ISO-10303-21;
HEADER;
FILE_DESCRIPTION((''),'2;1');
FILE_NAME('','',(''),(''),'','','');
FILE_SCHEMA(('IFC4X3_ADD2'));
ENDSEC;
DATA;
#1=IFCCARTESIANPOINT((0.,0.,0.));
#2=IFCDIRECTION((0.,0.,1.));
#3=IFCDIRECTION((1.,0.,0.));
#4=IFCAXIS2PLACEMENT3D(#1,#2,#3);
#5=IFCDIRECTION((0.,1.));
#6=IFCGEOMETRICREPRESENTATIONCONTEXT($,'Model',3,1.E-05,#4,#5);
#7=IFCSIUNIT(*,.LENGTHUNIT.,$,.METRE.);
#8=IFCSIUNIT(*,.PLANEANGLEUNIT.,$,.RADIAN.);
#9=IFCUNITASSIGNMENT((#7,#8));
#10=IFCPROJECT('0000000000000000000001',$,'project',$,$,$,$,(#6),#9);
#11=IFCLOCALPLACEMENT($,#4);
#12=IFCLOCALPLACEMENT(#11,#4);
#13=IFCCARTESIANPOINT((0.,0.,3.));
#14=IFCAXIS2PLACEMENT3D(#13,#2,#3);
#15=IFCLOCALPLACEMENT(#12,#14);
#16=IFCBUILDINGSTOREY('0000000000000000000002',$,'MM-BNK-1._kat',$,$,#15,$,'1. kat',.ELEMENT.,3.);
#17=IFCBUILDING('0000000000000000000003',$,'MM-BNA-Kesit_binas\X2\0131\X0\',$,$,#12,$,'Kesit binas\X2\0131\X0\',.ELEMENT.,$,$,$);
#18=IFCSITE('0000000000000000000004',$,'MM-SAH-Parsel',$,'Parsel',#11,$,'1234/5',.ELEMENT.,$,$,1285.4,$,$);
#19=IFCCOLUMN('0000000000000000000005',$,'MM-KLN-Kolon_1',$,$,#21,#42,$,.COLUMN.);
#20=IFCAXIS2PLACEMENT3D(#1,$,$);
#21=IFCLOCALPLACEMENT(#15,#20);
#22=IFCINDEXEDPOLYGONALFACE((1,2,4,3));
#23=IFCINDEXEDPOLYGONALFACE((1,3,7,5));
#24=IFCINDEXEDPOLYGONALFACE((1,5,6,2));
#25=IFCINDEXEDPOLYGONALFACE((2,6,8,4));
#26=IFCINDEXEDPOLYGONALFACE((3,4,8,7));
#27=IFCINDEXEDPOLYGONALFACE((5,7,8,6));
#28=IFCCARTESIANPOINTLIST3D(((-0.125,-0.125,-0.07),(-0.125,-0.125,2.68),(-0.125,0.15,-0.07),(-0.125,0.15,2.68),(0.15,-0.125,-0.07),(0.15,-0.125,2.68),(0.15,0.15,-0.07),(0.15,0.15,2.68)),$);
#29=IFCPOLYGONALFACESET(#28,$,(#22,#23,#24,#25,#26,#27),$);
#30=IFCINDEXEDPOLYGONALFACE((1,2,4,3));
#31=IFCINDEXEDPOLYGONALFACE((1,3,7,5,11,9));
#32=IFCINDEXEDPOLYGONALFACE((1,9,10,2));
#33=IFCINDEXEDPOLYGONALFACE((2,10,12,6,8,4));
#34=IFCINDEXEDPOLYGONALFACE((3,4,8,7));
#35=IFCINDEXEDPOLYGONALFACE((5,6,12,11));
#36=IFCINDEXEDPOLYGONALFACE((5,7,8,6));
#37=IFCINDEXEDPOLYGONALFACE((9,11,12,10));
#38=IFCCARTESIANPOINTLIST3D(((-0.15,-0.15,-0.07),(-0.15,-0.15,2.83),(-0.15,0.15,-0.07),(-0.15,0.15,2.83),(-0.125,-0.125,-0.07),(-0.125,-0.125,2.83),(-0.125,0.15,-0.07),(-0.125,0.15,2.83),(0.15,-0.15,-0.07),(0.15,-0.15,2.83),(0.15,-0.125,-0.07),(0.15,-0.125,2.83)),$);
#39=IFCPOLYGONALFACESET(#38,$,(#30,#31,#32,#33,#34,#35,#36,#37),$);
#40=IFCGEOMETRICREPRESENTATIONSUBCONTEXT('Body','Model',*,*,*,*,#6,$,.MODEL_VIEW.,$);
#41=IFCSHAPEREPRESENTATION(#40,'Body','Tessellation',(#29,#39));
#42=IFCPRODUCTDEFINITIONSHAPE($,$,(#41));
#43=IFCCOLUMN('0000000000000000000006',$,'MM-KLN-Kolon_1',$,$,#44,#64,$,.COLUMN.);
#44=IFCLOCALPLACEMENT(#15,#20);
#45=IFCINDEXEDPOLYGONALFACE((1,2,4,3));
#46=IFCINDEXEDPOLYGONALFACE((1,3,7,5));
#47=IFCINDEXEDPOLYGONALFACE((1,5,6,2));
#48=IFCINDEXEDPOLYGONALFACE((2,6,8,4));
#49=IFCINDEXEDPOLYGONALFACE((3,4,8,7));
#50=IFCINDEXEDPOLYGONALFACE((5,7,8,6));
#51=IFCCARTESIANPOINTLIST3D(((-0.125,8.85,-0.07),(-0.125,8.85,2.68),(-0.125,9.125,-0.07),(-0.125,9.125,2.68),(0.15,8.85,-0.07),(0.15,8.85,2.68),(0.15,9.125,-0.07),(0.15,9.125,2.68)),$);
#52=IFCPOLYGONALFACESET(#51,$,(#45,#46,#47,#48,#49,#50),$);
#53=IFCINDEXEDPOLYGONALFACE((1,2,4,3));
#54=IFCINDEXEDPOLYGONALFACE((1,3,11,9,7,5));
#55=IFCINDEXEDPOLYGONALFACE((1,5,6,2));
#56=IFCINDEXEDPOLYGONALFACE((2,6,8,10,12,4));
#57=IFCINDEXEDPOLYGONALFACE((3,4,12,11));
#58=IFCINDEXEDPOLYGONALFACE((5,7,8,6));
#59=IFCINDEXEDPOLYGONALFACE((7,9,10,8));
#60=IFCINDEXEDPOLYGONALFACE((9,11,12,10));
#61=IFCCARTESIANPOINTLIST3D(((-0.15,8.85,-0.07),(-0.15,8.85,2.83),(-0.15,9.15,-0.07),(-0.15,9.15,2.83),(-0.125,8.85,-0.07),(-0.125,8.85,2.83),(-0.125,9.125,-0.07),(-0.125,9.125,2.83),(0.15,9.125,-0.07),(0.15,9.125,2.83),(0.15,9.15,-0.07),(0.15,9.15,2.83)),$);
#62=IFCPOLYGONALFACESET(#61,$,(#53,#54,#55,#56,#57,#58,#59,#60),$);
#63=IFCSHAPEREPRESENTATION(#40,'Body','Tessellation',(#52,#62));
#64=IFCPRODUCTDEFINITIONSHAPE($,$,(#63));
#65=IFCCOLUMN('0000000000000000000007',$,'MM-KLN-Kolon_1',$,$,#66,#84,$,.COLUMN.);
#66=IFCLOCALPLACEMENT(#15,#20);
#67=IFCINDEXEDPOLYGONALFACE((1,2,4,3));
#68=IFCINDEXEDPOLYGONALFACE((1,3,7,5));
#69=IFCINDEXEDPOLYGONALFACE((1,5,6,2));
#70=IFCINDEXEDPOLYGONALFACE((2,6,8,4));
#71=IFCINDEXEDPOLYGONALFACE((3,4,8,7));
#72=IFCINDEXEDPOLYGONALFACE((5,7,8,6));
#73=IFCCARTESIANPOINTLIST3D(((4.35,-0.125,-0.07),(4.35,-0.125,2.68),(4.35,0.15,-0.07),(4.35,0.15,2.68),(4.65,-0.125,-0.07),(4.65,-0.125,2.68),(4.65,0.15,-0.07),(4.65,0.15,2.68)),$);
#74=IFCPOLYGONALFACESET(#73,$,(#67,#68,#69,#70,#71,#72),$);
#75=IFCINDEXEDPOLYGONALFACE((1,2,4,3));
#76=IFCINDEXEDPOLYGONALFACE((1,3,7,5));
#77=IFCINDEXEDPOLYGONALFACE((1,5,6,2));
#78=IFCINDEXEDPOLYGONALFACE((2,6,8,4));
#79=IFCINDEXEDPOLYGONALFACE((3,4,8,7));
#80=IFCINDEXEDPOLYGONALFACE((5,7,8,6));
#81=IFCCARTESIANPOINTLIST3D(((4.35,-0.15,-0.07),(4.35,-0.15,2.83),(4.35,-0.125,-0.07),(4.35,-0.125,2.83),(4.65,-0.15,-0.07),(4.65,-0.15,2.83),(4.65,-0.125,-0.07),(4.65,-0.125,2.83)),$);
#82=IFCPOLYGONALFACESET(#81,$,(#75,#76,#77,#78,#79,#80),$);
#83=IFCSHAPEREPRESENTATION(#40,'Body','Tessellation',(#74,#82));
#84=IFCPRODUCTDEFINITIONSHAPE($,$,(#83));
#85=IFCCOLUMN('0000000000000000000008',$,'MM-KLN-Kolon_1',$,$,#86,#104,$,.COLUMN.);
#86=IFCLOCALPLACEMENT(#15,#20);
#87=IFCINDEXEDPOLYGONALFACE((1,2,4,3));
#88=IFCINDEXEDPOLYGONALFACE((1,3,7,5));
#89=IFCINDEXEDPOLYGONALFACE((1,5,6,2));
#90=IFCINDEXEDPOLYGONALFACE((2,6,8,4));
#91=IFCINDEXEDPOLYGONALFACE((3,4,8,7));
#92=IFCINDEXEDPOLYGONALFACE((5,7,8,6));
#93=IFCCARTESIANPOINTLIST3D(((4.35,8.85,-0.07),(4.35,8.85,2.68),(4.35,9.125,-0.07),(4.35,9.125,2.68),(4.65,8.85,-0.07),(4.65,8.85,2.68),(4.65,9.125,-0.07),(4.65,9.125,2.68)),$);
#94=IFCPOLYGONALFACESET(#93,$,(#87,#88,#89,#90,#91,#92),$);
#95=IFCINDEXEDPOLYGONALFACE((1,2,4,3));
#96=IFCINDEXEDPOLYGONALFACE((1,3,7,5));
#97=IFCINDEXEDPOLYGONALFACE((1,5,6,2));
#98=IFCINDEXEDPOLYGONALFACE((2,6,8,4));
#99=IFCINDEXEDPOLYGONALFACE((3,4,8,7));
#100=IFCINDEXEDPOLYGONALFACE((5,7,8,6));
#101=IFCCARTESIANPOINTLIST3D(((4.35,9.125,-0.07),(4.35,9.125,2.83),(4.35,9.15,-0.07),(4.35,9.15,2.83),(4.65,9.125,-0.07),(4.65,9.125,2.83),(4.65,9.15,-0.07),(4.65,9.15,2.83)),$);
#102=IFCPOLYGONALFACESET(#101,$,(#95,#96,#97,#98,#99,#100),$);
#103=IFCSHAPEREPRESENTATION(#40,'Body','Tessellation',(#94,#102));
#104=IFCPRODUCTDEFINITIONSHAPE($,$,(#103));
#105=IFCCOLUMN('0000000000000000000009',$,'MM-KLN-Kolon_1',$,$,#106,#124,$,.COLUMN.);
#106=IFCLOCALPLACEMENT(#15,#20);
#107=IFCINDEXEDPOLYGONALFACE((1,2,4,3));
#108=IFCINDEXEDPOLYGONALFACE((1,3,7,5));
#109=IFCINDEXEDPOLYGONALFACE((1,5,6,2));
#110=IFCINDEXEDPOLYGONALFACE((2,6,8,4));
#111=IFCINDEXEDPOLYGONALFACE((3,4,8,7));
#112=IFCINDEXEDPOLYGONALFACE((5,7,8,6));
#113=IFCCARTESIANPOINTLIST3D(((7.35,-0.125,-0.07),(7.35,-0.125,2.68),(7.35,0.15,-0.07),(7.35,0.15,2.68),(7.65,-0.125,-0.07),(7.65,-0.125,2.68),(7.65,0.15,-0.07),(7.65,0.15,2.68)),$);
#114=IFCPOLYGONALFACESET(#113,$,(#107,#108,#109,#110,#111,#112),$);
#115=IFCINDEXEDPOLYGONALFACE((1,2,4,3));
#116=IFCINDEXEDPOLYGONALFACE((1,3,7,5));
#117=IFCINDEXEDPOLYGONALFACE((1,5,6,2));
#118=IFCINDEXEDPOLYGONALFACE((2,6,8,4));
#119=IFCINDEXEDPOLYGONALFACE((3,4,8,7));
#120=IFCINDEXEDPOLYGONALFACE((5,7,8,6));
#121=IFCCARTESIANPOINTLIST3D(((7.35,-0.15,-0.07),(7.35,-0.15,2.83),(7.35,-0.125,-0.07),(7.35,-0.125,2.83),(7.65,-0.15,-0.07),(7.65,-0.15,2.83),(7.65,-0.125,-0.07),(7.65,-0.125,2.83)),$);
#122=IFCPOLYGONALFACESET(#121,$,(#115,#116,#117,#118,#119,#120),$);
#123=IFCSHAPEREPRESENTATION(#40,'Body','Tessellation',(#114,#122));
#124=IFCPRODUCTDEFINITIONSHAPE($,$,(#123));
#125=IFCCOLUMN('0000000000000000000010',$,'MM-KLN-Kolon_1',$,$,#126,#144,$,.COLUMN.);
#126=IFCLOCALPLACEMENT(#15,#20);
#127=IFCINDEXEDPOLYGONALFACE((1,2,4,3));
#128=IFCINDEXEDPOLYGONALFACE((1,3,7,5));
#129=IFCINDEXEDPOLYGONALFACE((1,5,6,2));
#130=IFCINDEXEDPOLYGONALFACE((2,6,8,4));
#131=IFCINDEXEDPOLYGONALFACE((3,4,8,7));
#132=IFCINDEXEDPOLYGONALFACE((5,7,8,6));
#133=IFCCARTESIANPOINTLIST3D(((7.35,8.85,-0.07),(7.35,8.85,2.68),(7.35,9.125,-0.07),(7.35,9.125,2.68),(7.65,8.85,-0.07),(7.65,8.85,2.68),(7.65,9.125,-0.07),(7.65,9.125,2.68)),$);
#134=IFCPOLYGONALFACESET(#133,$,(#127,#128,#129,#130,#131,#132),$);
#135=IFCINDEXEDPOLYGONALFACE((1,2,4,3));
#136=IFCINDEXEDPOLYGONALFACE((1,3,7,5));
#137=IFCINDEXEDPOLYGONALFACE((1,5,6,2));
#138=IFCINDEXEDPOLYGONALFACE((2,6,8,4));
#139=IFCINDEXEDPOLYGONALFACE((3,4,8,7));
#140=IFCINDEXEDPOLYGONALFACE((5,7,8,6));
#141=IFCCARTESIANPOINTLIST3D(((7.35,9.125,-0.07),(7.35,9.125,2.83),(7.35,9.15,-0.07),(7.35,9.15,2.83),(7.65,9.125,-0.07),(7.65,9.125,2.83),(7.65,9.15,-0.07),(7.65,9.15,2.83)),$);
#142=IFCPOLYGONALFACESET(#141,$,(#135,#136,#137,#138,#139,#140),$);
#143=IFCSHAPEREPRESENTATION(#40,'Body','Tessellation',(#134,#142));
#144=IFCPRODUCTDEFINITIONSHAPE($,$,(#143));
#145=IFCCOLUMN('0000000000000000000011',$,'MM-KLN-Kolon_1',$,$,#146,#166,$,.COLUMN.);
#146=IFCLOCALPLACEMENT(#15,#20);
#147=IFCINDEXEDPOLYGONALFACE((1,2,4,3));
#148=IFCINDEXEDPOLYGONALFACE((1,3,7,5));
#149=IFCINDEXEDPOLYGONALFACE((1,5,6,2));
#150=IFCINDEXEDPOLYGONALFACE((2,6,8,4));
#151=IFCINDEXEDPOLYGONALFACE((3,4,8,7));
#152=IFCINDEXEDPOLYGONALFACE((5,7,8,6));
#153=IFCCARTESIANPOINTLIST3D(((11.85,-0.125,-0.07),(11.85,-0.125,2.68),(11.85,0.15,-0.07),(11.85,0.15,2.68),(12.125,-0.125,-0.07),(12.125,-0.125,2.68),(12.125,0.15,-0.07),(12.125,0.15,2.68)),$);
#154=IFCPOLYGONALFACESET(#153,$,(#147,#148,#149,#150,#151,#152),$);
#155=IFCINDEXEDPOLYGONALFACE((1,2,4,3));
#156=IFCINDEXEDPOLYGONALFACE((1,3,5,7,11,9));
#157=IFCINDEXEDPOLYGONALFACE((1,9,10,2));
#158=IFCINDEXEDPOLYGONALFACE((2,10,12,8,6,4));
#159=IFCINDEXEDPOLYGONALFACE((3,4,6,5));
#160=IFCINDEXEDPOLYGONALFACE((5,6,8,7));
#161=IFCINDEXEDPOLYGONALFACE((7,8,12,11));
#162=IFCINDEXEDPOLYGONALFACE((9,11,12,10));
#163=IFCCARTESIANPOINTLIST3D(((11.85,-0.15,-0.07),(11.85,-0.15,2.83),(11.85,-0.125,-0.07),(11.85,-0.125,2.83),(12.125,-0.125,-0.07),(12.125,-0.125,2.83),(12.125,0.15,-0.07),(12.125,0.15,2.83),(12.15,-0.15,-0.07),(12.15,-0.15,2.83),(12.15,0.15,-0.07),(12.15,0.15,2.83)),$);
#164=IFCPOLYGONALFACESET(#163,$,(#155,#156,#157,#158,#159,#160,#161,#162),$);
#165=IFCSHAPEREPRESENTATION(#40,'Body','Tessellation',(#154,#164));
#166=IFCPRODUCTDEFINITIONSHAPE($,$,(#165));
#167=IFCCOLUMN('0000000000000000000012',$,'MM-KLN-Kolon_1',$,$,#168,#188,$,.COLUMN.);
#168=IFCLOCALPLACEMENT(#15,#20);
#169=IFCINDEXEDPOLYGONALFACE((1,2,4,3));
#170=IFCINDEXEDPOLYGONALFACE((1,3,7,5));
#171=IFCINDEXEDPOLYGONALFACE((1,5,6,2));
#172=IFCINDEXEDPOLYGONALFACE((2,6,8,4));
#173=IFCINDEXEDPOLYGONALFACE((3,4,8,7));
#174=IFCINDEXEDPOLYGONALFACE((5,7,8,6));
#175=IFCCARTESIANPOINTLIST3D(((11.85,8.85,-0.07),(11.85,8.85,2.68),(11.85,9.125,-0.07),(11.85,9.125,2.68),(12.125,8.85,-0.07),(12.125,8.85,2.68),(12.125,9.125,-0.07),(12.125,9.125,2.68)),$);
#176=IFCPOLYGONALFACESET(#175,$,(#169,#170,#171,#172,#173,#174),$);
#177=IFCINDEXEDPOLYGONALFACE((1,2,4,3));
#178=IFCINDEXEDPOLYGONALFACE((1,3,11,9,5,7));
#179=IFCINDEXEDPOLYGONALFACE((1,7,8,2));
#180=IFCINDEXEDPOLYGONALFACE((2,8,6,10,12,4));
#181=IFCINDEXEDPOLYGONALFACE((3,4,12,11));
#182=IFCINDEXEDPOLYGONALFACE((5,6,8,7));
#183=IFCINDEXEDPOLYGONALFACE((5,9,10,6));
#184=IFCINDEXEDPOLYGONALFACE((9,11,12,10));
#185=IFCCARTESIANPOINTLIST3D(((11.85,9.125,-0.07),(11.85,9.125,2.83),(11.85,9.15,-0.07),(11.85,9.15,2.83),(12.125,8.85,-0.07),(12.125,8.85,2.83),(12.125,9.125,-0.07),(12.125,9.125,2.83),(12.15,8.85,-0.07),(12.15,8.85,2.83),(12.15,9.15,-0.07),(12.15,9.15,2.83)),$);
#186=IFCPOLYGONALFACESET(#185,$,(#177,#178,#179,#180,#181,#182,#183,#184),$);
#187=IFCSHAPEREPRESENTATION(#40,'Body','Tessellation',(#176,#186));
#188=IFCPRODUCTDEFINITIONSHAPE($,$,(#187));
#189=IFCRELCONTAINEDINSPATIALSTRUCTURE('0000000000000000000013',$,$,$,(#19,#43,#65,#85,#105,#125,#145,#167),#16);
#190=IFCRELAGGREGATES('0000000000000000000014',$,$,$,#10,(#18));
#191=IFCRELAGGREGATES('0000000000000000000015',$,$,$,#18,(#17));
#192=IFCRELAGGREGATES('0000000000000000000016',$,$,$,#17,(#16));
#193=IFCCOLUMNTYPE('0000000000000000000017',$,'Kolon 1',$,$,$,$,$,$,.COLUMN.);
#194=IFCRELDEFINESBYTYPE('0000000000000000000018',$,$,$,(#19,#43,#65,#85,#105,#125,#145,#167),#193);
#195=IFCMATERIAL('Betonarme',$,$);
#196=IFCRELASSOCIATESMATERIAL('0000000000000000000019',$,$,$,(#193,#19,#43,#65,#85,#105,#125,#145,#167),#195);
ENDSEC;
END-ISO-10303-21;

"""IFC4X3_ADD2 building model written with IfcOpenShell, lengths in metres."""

from ifc_helpers import new_model, si_unit, direction, frame, origin_with_axes, place, context, subcontext, project, spatial, polyline, rectangle, outline, extrude, material, material_profile, profile_set, type_object, element, save


model = new_model("IFC4X3_ADD2")

# Units and contexts
model_context = context("Model", 3, precision=1e-05, world=origin_with_axes(), true_north=direction((0.0, 1.0)))
body_context = subcontext(model_context, "Body", "Model", "MODEL_VIEW")
ifc_project = project(units=[si_unit("LENGTHUNIT", "METRE"), si_unit("PLANEANGLEUNIT", "RADIAN")], contexts=[model_context])

# Site, building, storey
site_placement = place(None, origin_with_axes())
site = spatial("IfcSite", under=ifc_project, at=site_placement, Name="MM-SAH-Parsel", ObjectType="Parsel", LongName="1234/5", CompositionType="ELEMENT", RefElevation=1285.4)
building_placement = place(site_placement, origin_with_axes())
building = spatial("IfcBuilding", under=site, at=building_placement, Name="MM-BNA-Kesit_binası", LongName="Kesit binası", CompositionType="ELEMENT")
storey_placement = place(building_placement, frame((0.0, 0.0, 3.0), z_axis=(0.0, 0.0, 1.0), x_axis=(1.0, 0.0, 0.0)))
storey = spatial("IfcBuildingStorey", under=building, at=storey_placement, Name="MM-BNK-1._kat", LongName="1. kat", CompositionType="ELEMENT", Elevation=3.0)

# Columns
ifc_material_1 = material(Name="Betonarme")
ifc_material_profile_1 = material_profile(ifc_material_1, rectangle(XDim=0.3, YDim=0.3), Category="LoadBearing")
ifc_profile_set_1 = profile_set([ifc_material_profile_1], Name="Kolon 1")
column_type = type_object("IfcColumnType", Name="Kolon 1", PredefinedType="COLUMN", material=ifc_profile_set_1)
column_1_placement = place(storey_placement, origin_with_axes())
element("IfcColumn", 1, at=column_1_placement, inside=storey, type_object=column_type, material=ifc_material_1, Name="MM-KLN-Kolon_1", PredefinedType="COLUMN", context=body_context, shape_type="SweptSolid", body=[
    extrude(outline(polyline([(0.15, -0.125), (0.15, 0.15), (-0.125, 0.15), (-0.125, -0.125), (0.15, -0.125)])), frame((0.0, 0.0, -0.07)), (0.0, 0.0, 1.0), 2.75),
    extrude(outline(polyline([(-0.15, -0.15), (0.15, -0.15), (0.15, -0.125), (-0.125, -0.125), (-0.125, 0.15), (-0.15, 0.15), (-0.15, -0.15)])), frame((0.0, 0.0, -0.07)), (0.0, 0.0, 1.0), 2.9),
])
column_2_placement = place(storey_placement, origin_with_axes())
element("IfcColumn", 2, at=column_2_placement, inside=storey, type_object=column_type, material=ifc_material_1, Name="MM-KLN-Kolon_1", PredefinedType="COLUMN", context=body_context, shape_type="SweptSolid", body=[
    extrude(outline(polyline([(-0.125, 8.85), (0.15, 8.85), (0.15, 9.125), (-0.125, 9.125), (-0.125, 8.85)])), frame((0.0, 0.0, -0.07)), (0.0, 0.0, 1.0), 2.75),
    extrude(outline(polyline([(-0.15, 8.85), (-0.125, 8.85), (-0.125, 9.125), (0.15, 9.125), (0.15, 9.15), (-0.15, 9.15), (-0.15, 8.85)])), frame((0.0, 0.0, -0.07)), (0.0, 0.0, 1.0), 2.9),
])
column_3_placement = place(storey_placement, origin_with_axes())
element("IfcColumn", 3, at=column_3_placement, inside=storey, type_object=column_type, material=ifc_material_1, Name="MM-KLN-Kolon_1", PredefinedType="COLUMN", context=body_context, shape_type="SweptSolid", body=[
    extrude(outline(polyline([(4.65, -0.125), (4.65, 0.15), (4.35, 0.15), (4.35, -0.125), (4.65, -0.125)])), frame((0.0, 0.0, -0.07)), (0.0, 0.0, 1.0), 2.75),
    extrude(outline(polyline([(4.35, -0.15), (4.65, -0.15), (4.65, -0.125), (4.35, -0.125), (4.35, -0.15)])), frame((0.0, 0.0, -0.07)), (0.0, 0.0, 1.0), 2.9),
])
column_4_placement = place(storey_placement, origin_with_axes())
element("IfcColumn", 4, at=column_4_placement, inside=storey, type_object=column_type, material=ifc_material_1, Name="MM-KLN-Kolon_1", PredefinedType="COLUMN", context=body_context, shape_type="SweptSolid", body=[
    extrude(outline(polyline([(4.35, 8.85), (4.65, 8.85), (4.65, 9.125), (4.35, 9.125), (4.35, 8.85)])), frame((0.0, 0.0, -0.07)), (0.0, 0.0, 1.0), 2.75),
    extrude(outline(polyline([(4.65, 9.125), (4.65, 9.15), (4.35, 9.15), (4.35, 9.125), (4.65, 9.125)])), frame((0.0, 0.0, -0.07)), (0.0, 0.0, 1.0), 2.9),
])
column_5_placement = place(storey_placement, origin_with_axes())
element("IfcColumn", 5, at=column_5_placement, inside=storey, type_object=column_type, material=ifc_material_1, Name="MM-KLN-Kolon_1", PredefinedType="COLUMN", context=body_context, shape_type="SweptSolid", body=[
    extrude(outline(polyline([(7.65, -0.125), (7.65, 0.15), (7.35, 0.15), (7.35, -0.125), (7.65, -0.125)])), frame((0.0, 0.0, -0.07)), (0.0, 0.0, 1.0), 2.75),
    extrude(outline(polyline([(7.35, -0.15), (7.65, -0.15), (7.65, -0.125), (7.35, -0.125), (7.35, -0.15)])), frame((0.0, 0.0, -0.07)), (0.0, 0.0, 1.0), 2.9),
])
column_6_placement = place(storey_placement, origin_with_axes())
element("IfcColumn", 6, at=column_6_placement, inside=storey, type_object=column_type, material=ifc_material_1, Name="MM-KLN-Kolon_1", PredefinedType="COLUMN", context=body_context, shape_type="SweptSolid", body=[
    extrude(outline(polyline([(7.35, 8.85), (7.65, 8.85), (7.65, 9.125), (7.35, 9.125), (7.35, 8.85)])), frame((0.0, 0.0, -0.07)), (0.0, 0.0, 1.0), 2.75),
    extrude(outline(polyline([(7.65, 9.125), (7.65, 9.15), (7.35, 9.15), (7.35, 9.125), (7.65, 9.125)])), frame((0.0, 0.0, -0.07)), (0.0, 0.0, 1.0), 2.9),
])
column_7_placement = place(storey_placement, origin_with_axes())
element("IfcColumn", 7, at=column_7_placement, inside=storey, type_object=column_type, material=ifc_material_1, Name="MM-KLN-Kolon_1", PredefinedType="COLUMN", context=body_context, shape_type="SweptSolid", body=[
    extrude(outline(polyline([(12.125, 0.15), (11.85, 0.15), (11.85, -0.125), (12.125, -0.125), (12.125, 0.15)])), frame((0.0, 0.0, -0.07)), (0.0, 0.0, 1.0), 2.75),
    extrude(outline(polyline([(11.85, -0.15), (12.15, -0.15), (12.15, 0.15), (12.125, 0.15), (12.125, -0.125), (11.85, -0.125), (11.85, -0.15)])), frame((0.0, 0.0, -0.07)), (0.0, 0.0, 1.0), 2.9),
])
column_8_placement = place(storey_placement, origin_with_axes())
element("IfcColumn", 8, at=column_8_placement, inside=storey, type_object=column_type, material=ifc_material_1, Name="MM-KLN-Kolon_1", PredefinedType="COLUMN", context=body_context, shape_type="SweptSolid", body=[
    extrude(outline(polyline([(11.85, 8.85), (12.125, 8.85), (12.125, 9.125), (11.85, 9.125), (11.85, 8.85)])), frame((0.0, 0.0, -0.07)), (0.0, 0.0, 1.0), 2.75),
    extrude(outline(polyline([(12.125, 8.85), (12.15, 8.85), (12.15, 9.15), (11.85, 9.15), (11.85, 9.125), (12.125, 9.125), (12.125, 8.85)])), frame((0.0, 0.0, -0.07)), (0.0, 0.0, 1.0), 2.9),
])

save(model, "model.ifc")
